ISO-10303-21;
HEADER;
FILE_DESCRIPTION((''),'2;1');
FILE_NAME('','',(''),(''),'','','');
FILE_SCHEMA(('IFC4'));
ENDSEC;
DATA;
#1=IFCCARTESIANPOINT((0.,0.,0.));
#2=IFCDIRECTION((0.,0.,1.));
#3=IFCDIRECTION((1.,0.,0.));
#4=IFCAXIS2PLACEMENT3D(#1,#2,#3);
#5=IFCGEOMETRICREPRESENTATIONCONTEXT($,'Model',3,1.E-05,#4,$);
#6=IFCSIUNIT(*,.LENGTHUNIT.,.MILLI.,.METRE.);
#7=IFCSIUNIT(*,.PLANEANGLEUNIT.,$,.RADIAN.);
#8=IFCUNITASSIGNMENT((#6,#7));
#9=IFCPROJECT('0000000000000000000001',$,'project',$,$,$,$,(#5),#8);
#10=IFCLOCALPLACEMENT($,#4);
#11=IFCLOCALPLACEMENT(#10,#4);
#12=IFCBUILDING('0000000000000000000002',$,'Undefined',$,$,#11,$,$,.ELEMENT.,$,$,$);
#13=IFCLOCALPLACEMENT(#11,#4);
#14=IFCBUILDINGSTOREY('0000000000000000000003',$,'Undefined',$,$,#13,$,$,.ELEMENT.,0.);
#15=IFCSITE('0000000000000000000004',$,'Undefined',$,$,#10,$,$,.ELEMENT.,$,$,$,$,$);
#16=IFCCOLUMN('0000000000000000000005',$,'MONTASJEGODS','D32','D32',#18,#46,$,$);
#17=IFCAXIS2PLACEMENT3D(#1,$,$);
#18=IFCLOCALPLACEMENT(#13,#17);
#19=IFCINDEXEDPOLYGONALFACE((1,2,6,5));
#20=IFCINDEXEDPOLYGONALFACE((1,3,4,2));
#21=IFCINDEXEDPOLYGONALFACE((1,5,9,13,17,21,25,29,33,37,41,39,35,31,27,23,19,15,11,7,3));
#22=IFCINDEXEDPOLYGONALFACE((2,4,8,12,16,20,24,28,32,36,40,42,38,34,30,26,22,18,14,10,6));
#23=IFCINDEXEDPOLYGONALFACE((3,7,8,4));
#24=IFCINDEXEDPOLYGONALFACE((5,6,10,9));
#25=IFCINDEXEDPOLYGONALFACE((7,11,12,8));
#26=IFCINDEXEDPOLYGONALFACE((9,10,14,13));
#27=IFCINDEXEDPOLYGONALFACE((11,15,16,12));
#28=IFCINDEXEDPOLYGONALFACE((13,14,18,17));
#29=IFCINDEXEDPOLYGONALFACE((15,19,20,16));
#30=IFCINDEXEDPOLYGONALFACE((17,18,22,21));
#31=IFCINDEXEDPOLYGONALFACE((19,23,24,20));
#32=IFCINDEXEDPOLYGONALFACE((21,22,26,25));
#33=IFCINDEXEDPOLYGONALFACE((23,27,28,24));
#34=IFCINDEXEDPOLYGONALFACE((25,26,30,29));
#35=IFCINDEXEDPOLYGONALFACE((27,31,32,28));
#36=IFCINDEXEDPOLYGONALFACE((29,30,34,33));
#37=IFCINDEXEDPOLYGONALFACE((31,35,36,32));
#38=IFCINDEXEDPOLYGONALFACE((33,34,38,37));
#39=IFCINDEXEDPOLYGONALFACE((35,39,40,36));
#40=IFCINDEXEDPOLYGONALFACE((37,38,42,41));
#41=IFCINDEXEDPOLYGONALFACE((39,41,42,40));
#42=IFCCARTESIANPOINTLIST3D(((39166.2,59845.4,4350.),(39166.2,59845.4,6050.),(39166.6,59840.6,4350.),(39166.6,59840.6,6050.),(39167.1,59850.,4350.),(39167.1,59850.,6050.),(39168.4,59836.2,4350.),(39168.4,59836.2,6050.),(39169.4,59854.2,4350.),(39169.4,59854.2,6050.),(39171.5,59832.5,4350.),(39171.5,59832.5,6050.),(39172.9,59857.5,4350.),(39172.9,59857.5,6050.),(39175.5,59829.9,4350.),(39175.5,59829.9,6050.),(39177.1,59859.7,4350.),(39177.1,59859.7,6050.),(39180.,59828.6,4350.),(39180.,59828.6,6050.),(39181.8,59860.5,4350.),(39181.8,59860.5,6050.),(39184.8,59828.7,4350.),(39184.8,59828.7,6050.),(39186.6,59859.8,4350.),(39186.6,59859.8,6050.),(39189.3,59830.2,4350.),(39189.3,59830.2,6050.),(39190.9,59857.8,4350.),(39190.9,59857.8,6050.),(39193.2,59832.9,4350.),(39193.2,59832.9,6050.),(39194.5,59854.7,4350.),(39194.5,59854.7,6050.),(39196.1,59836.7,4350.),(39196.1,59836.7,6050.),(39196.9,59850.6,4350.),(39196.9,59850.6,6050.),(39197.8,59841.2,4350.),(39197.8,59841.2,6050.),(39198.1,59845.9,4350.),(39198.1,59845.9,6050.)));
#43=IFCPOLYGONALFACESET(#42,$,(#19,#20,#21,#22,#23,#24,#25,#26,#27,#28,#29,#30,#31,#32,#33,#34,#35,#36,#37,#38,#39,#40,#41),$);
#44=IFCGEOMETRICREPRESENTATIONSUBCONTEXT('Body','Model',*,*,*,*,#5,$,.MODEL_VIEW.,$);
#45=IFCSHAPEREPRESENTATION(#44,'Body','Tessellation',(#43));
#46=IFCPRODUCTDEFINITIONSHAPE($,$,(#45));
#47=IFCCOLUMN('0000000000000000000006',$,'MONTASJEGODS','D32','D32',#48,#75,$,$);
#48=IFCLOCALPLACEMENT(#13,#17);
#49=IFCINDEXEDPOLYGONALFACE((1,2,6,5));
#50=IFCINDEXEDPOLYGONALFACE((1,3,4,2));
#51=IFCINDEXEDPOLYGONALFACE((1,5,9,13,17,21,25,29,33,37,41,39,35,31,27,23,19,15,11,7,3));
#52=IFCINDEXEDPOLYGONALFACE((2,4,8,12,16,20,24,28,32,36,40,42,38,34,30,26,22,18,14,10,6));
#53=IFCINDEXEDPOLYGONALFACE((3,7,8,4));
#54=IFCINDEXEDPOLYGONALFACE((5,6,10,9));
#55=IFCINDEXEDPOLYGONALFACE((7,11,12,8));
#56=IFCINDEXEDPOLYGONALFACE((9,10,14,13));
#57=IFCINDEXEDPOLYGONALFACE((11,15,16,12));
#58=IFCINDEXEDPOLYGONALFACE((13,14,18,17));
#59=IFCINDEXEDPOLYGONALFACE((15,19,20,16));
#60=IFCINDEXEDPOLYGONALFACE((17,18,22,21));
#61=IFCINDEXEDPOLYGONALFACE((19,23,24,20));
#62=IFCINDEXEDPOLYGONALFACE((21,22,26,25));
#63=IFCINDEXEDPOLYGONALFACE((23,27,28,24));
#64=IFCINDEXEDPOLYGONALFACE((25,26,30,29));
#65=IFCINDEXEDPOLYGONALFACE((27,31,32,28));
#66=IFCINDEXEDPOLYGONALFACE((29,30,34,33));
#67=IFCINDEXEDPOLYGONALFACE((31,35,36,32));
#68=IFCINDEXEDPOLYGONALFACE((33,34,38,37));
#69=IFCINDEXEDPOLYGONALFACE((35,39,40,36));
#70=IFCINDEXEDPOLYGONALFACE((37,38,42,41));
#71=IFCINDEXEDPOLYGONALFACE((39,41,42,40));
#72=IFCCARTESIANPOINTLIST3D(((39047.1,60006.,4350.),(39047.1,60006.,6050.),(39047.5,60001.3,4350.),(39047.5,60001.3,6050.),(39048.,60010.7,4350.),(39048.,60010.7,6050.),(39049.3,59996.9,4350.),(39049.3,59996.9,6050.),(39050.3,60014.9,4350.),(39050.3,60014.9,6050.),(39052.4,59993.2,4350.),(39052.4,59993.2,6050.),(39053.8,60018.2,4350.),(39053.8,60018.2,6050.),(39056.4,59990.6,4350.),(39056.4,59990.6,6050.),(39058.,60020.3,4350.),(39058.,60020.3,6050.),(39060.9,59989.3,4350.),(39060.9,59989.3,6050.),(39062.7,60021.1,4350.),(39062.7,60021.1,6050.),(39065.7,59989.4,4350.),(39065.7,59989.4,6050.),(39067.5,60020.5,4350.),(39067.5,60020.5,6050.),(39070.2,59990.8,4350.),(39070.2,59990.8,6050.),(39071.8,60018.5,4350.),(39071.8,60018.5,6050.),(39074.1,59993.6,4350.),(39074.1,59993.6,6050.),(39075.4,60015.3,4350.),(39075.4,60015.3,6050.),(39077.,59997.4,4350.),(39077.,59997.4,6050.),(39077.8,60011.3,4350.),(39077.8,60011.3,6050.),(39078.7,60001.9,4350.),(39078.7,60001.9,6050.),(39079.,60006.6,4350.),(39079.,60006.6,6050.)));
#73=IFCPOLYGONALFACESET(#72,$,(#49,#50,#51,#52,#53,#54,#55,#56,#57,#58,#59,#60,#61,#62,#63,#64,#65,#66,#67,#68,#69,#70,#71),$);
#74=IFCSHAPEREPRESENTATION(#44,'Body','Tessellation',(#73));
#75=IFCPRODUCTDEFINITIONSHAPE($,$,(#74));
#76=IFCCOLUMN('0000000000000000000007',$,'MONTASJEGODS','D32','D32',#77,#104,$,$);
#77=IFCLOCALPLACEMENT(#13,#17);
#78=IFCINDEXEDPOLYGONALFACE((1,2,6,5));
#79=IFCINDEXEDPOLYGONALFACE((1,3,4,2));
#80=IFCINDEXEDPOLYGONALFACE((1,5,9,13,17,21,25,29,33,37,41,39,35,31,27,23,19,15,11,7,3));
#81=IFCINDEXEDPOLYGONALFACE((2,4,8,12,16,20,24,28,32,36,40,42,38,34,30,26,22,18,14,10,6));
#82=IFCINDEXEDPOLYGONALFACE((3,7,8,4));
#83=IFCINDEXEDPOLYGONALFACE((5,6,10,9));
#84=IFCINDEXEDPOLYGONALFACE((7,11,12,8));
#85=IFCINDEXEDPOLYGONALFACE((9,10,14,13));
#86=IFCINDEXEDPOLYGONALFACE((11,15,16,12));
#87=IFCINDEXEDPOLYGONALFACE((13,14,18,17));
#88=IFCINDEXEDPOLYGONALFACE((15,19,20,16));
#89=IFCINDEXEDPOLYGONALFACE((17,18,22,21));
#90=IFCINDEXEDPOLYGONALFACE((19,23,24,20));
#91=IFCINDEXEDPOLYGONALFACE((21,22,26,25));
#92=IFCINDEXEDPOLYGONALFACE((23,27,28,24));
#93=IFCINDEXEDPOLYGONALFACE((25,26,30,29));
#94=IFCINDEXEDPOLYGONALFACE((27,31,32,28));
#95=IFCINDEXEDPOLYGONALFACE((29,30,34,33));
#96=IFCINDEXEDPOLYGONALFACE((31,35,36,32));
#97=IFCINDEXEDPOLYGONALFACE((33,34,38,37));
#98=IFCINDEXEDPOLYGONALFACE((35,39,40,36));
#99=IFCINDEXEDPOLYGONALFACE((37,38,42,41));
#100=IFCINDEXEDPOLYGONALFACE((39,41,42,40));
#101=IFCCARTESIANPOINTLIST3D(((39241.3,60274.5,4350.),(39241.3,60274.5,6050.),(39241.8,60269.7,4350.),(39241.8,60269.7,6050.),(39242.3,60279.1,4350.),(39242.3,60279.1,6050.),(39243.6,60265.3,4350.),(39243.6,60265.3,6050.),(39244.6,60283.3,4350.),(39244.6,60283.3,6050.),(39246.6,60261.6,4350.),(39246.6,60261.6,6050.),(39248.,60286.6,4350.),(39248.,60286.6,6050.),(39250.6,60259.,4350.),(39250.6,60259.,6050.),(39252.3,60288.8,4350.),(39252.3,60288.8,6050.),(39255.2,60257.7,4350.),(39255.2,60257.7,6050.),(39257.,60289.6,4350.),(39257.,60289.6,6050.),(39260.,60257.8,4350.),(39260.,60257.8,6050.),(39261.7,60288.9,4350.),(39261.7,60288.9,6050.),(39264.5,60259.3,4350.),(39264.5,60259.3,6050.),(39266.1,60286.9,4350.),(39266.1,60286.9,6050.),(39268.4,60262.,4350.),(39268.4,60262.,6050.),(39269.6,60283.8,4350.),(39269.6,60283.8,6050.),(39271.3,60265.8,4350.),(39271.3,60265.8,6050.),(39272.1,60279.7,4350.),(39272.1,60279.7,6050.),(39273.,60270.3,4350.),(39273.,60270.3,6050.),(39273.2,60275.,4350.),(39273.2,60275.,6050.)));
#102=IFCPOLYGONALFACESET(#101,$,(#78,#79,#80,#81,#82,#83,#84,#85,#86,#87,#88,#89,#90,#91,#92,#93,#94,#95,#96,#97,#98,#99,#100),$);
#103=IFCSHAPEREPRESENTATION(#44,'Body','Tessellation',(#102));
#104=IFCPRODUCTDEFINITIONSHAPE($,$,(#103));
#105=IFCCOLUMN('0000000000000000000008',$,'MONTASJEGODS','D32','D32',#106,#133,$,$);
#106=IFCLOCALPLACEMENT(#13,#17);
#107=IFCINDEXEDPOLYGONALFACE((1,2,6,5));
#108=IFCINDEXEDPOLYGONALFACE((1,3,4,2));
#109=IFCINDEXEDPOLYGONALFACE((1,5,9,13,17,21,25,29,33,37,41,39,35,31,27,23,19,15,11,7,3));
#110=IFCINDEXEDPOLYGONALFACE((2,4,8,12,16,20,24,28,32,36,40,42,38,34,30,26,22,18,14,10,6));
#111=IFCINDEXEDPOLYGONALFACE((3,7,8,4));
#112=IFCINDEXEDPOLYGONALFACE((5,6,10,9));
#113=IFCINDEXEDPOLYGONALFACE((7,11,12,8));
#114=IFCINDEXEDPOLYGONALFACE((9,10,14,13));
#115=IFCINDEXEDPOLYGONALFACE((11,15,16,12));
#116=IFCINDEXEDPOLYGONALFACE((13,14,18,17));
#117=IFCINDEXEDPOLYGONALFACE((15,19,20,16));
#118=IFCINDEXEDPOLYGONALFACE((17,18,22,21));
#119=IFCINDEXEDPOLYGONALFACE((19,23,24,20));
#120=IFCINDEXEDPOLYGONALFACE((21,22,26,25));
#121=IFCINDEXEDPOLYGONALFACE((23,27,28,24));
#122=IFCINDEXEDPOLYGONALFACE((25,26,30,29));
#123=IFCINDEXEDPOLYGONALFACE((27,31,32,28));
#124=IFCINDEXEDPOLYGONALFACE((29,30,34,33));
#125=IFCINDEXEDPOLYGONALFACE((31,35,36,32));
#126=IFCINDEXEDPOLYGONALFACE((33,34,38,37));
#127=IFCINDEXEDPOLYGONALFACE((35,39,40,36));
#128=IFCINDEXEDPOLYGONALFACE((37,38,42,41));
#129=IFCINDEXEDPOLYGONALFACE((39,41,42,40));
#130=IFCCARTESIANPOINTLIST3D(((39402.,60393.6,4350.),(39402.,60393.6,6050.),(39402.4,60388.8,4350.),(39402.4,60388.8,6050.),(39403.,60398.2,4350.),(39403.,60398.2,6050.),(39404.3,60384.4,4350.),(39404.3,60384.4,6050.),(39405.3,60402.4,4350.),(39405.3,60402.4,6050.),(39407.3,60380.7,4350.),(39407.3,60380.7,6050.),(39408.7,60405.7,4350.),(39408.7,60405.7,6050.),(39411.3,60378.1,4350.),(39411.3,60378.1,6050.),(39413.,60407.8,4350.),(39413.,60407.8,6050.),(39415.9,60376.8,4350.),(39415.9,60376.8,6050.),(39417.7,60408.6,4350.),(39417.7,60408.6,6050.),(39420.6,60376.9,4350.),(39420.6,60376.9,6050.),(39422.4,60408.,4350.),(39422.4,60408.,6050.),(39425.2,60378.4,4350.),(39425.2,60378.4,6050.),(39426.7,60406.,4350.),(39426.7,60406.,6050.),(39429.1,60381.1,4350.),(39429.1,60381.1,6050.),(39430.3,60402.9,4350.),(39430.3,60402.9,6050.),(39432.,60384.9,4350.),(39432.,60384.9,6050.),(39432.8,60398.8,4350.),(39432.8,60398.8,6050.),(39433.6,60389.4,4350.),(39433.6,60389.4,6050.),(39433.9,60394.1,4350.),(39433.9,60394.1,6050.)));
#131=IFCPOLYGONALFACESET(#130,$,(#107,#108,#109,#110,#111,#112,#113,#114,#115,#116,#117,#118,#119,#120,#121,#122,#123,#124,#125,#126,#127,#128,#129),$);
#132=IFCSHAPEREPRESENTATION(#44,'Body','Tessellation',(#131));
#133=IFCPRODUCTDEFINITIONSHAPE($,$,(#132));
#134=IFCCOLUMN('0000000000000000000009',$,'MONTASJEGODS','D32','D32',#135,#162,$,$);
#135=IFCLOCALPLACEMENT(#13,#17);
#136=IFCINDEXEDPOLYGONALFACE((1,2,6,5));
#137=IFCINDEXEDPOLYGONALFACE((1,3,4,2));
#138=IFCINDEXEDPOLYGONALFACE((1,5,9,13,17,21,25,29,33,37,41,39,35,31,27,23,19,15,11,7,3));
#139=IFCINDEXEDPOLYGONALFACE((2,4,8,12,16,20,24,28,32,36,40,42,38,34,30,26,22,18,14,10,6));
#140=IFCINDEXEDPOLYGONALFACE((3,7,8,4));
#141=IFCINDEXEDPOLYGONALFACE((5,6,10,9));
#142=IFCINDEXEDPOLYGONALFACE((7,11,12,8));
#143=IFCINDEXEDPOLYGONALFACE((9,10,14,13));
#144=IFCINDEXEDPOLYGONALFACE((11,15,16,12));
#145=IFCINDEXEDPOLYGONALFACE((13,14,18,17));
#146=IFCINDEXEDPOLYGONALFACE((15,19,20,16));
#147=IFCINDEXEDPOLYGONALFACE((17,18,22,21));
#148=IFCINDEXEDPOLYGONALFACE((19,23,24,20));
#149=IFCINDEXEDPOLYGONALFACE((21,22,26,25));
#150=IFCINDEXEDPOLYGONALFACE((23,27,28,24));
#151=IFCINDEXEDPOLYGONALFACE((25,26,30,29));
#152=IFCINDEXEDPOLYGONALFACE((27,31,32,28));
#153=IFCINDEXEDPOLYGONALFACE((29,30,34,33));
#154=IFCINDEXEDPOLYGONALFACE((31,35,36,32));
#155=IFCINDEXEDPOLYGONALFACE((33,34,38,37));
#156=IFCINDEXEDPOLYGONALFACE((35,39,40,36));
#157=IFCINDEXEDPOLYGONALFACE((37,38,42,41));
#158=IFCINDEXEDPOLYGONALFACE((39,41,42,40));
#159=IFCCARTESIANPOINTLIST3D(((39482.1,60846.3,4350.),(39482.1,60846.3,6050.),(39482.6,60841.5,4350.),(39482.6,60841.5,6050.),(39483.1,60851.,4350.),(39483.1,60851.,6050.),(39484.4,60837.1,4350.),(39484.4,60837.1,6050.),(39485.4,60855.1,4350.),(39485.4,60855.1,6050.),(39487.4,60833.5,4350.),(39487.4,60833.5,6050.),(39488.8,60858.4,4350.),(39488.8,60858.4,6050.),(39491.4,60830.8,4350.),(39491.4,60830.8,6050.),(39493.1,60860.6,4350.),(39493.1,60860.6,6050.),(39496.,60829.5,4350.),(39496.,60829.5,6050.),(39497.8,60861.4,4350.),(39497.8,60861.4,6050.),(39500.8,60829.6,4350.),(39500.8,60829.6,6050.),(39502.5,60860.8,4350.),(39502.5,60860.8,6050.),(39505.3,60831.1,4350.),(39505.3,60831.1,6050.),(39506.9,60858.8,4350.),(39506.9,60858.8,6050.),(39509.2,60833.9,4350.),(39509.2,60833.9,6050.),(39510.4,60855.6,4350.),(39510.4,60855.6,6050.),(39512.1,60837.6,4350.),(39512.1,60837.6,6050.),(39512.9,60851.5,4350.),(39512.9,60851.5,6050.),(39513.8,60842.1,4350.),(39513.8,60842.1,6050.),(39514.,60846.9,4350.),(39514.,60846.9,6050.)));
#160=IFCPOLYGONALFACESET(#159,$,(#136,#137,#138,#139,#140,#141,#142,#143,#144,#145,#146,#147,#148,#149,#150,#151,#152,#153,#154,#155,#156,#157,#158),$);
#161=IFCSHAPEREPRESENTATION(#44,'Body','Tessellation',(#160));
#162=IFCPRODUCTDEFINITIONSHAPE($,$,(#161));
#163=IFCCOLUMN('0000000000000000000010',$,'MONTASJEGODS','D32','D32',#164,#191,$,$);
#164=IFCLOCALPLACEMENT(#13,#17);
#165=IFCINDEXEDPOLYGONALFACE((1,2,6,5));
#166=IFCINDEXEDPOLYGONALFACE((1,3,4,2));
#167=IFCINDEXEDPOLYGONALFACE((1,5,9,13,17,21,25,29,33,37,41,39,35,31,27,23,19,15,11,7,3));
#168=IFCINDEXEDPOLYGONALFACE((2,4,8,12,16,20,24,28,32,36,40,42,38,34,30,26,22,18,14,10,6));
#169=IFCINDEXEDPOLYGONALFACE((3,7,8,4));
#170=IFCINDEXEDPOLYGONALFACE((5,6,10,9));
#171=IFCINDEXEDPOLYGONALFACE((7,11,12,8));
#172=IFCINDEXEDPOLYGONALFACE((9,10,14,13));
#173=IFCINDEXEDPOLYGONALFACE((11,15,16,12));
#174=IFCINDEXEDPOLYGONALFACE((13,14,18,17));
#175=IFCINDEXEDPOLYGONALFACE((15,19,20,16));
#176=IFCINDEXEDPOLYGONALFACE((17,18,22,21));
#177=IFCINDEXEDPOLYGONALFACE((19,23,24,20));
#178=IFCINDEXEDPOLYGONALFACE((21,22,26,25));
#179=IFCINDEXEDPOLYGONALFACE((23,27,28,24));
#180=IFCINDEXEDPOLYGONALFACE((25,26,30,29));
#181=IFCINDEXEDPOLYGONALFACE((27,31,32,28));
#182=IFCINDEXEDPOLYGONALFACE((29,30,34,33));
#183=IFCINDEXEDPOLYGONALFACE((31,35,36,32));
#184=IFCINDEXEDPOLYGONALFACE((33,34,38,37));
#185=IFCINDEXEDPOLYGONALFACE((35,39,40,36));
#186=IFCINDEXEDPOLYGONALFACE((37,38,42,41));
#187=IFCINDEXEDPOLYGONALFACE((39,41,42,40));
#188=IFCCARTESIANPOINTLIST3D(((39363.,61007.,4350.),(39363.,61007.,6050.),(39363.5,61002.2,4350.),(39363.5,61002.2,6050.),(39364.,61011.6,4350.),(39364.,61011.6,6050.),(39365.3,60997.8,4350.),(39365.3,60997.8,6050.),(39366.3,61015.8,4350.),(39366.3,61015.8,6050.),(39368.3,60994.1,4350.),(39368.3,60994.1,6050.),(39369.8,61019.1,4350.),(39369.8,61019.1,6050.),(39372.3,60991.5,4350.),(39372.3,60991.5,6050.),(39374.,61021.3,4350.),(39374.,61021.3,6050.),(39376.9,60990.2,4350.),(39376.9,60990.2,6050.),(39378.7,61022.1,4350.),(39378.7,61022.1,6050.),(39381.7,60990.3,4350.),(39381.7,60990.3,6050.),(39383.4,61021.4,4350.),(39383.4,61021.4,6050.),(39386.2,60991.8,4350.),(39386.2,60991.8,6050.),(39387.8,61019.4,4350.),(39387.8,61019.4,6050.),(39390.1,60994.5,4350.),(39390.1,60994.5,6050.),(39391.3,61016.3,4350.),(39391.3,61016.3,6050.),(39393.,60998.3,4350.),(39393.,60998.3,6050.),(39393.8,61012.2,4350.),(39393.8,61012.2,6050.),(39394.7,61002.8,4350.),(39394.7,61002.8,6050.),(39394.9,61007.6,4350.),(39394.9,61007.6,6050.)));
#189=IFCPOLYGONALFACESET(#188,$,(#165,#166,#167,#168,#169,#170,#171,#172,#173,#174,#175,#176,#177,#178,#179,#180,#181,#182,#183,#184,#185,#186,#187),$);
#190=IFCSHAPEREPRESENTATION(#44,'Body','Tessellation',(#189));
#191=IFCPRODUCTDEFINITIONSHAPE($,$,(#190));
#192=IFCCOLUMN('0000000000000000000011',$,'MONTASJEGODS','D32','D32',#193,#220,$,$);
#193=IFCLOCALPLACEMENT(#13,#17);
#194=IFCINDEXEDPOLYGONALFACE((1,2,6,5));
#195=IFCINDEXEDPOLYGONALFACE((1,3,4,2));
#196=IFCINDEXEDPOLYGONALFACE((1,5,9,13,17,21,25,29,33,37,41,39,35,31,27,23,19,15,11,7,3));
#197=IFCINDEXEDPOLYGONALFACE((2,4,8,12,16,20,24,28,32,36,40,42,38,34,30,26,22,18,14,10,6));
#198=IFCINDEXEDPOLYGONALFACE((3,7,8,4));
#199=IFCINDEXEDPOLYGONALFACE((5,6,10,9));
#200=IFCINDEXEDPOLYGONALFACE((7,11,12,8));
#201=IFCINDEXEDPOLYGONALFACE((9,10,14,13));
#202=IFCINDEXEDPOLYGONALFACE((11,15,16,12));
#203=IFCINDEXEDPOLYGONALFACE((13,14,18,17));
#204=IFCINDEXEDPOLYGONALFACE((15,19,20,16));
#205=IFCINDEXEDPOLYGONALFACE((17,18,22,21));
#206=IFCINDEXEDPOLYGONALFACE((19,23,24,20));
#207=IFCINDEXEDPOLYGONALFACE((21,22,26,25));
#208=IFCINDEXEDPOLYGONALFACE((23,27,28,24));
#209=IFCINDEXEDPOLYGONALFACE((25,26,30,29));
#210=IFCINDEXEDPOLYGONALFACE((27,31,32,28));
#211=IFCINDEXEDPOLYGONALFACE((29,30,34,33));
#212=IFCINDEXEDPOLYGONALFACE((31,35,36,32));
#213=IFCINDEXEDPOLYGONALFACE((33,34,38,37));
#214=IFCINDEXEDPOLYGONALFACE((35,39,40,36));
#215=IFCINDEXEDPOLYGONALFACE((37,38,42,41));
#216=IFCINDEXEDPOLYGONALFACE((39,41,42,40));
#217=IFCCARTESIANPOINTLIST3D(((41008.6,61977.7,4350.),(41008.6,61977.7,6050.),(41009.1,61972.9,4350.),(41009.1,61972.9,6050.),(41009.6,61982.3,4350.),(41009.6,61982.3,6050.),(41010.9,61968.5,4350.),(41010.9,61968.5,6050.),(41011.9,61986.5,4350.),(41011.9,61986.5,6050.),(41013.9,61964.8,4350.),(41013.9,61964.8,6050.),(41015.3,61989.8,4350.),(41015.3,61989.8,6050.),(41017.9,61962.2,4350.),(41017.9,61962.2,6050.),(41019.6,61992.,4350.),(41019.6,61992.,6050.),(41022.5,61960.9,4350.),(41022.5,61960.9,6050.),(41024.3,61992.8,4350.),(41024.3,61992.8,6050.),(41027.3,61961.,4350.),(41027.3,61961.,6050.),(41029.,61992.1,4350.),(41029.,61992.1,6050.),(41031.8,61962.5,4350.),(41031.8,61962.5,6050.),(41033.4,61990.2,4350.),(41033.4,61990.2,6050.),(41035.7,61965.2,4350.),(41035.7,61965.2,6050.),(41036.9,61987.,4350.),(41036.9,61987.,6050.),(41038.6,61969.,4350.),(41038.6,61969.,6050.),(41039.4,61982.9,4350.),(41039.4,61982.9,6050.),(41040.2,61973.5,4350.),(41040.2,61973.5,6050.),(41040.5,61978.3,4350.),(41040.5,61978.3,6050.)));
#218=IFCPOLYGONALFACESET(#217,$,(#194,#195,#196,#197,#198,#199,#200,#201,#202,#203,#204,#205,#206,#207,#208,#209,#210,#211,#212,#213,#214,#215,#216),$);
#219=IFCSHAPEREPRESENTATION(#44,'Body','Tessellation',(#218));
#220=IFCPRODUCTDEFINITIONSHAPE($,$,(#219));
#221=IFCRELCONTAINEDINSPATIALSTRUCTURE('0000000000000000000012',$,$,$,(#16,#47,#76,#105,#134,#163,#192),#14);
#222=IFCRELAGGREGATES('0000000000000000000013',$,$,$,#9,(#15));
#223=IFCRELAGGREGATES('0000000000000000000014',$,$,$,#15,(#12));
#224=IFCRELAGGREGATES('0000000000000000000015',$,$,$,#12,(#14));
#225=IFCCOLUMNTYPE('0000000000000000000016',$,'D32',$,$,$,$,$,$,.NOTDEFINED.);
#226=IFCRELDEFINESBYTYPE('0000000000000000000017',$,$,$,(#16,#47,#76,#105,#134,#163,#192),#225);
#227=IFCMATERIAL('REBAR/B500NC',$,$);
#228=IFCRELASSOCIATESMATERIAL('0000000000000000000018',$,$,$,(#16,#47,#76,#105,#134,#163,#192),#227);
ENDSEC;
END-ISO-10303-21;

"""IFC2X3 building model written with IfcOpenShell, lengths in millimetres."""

from ifc_helpers import new_model, si_unit, frame, origin_with_axes, origin_2d_with_axis, place, context, subcontext, project, spatial, circle, extrude, material, type_object, element, save


model = new_model("IFC2X3")

# Units and contexts
model_context = context("Model", 3, precision=1e-05, world=origin_with_axes())
body_context = subcontext(model_context, "Body", "Model", "MODEL_VIEW")
ifc_project = project(units=[si_unit("LENGTHUNIT", "METRE", prefix="MILLI"), si_unit("PLANEANGLEUNIT", "RADIAN")], contexts=[model_context])

# Site, building, storey
site_placement = place(None, origin_with_axes())
site = spatial("IfcSite", under=ifc_project, at=site_placement, Name="Undefined", CompositionType="ELEMENT")
building_placement = place(site_placement, origin_with_axes())
building = spatial("IfcBuilding", under=site, at=building_placement, Name="Undefined", CompositionType="ELEMENT")
storey_placement = place(building_placement, origin_with_axes())
storey = spatial("IfcBuildingStorey", under=building, at=storey_placement, Name="Undefined", CompositionType="ELEMENT", Elevation=0.0)

# Columns
ifc_material_1 = material(Name="REBAR/B500NC")
column_type_1 = type_object("IfcColumnType", Name="D32", PredefinedType="NOTDEFINED")
for number, where, z_axis, x_axis, name in (
    (1, (39182.1, 59844.5, 4350.0), (0.0, 0.0, 1.0), (-0.892819, -0.450415, 0.0), "MONTASJEGODS"),
    (2, (39063.0, 60005.1, 4350.0), (0.0, 0.0, 1.0), (-0.892819, -0.450415, 0.0), "MONTASJEGODS"),
    (3, (39257.3, 60273.6, 4350.0), (0.0, 0.0, 1.0), (-0.892819, -0.450415, 0.0), "MONTASJEGODS"),
    (4, (39418.0, 60392.6, 4350.0), (0.0, 0.0, 1.0), (-0.892819, -0.450415, 0.0), "MONTASJEGODS"),
    (5, (39498.1, 60845.4, 4350.0), (0.0, 0.0, 1.0), (-0.892819, -0.450415, 0.0), "MONTASJEGODS"),
    (6, (39379.0, 61006.1, 4350.0), (0.0, 0.0, 1.0), (-0.892819, -0.450415, 0.0), "MONTASJEGODS"),
    (7, (41024.6, 61976.8, 4350.0), (0.0, 0.0, 1.0), (-0.892819, -0.450415, 0.0), "MONTASJEGODS"),
):
    element("IfcColumn", number, at=place(storey_placement, frame(where, z_axis=z_axis, x_axis=x_axis)), inside=storey, type_object=column_type_1, material=ifc_material_1, Name=name, Description="D32", ObjectType="D32", context=body_context, shape_type="SweptSolid", body=[
        extrude(circle(Radius=16.0, at=origin_2d_with_axis()), frame((0.0, 0.0, 1700.0), z_axis=(0.0, 0.0, -1.0), x_axis=(0.0, 1.0, 0.0)), (0.0, 0.0, 1.0), 1700.0),
    ])

save(model, "model.ifc")
